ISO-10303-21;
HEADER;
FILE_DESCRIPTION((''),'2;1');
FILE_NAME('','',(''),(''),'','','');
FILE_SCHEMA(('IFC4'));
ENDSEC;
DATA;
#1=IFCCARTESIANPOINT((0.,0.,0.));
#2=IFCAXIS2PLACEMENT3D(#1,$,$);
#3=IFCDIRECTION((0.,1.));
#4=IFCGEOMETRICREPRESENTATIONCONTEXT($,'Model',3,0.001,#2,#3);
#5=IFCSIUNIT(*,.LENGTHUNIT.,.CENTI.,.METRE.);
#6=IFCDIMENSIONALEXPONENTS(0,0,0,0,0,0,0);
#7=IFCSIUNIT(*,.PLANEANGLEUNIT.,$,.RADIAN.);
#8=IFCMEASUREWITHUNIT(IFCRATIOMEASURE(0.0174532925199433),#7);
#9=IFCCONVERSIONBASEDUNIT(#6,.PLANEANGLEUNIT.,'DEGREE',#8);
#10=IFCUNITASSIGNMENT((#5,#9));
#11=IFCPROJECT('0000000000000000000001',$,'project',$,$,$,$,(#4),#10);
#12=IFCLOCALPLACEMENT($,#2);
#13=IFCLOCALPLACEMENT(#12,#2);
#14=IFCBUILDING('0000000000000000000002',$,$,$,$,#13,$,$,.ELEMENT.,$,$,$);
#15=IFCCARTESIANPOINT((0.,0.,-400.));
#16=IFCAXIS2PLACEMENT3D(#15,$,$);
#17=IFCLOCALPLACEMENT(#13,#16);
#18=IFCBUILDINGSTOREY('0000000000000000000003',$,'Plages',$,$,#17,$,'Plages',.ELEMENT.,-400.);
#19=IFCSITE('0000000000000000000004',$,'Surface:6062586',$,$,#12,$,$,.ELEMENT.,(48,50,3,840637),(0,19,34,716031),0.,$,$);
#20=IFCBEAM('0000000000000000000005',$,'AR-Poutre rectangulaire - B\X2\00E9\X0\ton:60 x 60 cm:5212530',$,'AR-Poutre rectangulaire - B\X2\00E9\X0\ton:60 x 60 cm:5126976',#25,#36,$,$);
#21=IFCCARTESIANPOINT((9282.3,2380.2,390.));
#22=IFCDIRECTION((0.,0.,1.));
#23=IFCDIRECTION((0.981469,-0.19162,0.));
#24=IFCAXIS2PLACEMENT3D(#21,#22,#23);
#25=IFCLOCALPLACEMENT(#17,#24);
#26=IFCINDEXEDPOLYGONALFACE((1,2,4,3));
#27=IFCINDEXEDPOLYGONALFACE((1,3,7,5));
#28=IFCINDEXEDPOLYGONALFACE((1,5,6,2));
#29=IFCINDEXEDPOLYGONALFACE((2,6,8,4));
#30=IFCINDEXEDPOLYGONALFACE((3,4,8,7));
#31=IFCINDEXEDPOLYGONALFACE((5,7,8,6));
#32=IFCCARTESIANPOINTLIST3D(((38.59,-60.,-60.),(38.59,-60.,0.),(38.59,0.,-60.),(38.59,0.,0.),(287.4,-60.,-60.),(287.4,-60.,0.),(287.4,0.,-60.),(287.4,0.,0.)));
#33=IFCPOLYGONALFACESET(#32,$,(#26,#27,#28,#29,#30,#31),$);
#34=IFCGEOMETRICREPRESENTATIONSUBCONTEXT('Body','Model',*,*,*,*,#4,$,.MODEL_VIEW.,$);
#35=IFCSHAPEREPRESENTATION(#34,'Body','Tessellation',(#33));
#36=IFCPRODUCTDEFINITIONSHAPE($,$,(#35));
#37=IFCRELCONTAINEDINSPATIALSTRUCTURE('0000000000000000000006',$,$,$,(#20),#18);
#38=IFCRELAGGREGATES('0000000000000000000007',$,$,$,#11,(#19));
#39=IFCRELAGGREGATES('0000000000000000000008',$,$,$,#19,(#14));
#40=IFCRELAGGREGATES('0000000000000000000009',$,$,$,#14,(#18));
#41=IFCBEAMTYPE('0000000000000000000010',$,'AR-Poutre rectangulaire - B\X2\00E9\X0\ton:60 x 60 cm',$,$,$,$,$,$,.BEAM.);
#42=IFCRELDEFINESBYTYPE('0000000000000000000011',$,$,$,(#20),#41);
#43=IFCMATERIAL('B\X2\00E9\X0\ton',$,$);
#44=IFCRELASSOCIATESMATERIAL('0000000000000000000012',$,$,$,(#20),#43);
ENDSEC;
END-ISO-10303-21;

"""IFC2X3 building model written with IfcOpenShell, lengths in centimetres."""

from ifc_helpers import new_model, entity, si_unit, converted_unit, direction, frame, frame_2d, origin, place, context, subcontext, project, spatial, rectangle, extrude, material, type_object, element, save


model = new_model("IFC2X3")

# Units and contexts
model_context = context("Model", 3, precision=0.001, world=origin(), true_north=direction((0.0, 1.0)))
body_context = subcontext(model_context, "Body", "Model", "MODEL_VIEW")
ifc_project = project(units=[si_unit("LENGTHUNIT", "METRE", prefix="CENTI"), converted_unit("PLANEANGLEUNIT", "DEGREE", entity("IfcRatioMeasure", 0.0174532925199433), si_unit("PLANEANGLEUNIT", "RADIAN"), dimensions=[0, 0, 0, 0, 0, 0, 0])], contexts=[model_context])

# Site, building, storey
site_placement = place(None, origin())
site = spatial("IfcSite", under=ifc_project, at=site_placement, Name="Surface:6062586", CompositionType="ELEMENT", RefLatitude=(48, 50, 3, 840637), RefLongitude=(0, 19, 34, 716031), RefElevation=0.0)
building_placement = place(site_placement, origin())
building = spatial("IfcBuilding", under=site, at=building_placement, CompositionType="ELEMENT")
storey_placement = place(building_placement, frame((0.0, 0.0, -400.0)))
storey = spatial("IfcBuildingStorey", under=building, at=storey_placement, Name="Plages", LongName="Plages", CompositionType="ELEMENT", Elevation=-400.0)

# Beam
ifc_material_1 = material(Name="Béton")
beam_type_1 = type_object("IfcBeamType", Name="AR-Poutre rectangulaire - Béton:60 x 60 cm", PredefinedType="BEAM")
beam_1_placement = place(storey_placement, frame((9282.3, 2380.2, 390.0), z_axis=(0.0, 0.0, 1.0), x_axis=(0.981469, -0.19162, 0.0)))
element("IfcBeam", 1, at=beam_1_placement, inside=storey, type_object=beam_type_1, material=ifc_material_1, Name="AR-Poutre rectangulaire - Béton:60 x 60 cm:5212530", ObjectType="AR-Poutre rectangulaire - Béton:60 x 60 cm:5126976", context=body_context, shape_type="SweptSolid", body=[
    extrude(rectangle(XDim=60.0, YDim=60.0, at=frame_2d((0.0, 0.0), x_axis=(1.0, 0.0))), frame((38.59, -30.0, -30.0), z_axis=(1.0, 0.0, 0.0), x_axis=(0.0, 0.0, -1.0)), (0.0, 0.0, 1.0), 248.81),
])

save(model, "model.ifc")
